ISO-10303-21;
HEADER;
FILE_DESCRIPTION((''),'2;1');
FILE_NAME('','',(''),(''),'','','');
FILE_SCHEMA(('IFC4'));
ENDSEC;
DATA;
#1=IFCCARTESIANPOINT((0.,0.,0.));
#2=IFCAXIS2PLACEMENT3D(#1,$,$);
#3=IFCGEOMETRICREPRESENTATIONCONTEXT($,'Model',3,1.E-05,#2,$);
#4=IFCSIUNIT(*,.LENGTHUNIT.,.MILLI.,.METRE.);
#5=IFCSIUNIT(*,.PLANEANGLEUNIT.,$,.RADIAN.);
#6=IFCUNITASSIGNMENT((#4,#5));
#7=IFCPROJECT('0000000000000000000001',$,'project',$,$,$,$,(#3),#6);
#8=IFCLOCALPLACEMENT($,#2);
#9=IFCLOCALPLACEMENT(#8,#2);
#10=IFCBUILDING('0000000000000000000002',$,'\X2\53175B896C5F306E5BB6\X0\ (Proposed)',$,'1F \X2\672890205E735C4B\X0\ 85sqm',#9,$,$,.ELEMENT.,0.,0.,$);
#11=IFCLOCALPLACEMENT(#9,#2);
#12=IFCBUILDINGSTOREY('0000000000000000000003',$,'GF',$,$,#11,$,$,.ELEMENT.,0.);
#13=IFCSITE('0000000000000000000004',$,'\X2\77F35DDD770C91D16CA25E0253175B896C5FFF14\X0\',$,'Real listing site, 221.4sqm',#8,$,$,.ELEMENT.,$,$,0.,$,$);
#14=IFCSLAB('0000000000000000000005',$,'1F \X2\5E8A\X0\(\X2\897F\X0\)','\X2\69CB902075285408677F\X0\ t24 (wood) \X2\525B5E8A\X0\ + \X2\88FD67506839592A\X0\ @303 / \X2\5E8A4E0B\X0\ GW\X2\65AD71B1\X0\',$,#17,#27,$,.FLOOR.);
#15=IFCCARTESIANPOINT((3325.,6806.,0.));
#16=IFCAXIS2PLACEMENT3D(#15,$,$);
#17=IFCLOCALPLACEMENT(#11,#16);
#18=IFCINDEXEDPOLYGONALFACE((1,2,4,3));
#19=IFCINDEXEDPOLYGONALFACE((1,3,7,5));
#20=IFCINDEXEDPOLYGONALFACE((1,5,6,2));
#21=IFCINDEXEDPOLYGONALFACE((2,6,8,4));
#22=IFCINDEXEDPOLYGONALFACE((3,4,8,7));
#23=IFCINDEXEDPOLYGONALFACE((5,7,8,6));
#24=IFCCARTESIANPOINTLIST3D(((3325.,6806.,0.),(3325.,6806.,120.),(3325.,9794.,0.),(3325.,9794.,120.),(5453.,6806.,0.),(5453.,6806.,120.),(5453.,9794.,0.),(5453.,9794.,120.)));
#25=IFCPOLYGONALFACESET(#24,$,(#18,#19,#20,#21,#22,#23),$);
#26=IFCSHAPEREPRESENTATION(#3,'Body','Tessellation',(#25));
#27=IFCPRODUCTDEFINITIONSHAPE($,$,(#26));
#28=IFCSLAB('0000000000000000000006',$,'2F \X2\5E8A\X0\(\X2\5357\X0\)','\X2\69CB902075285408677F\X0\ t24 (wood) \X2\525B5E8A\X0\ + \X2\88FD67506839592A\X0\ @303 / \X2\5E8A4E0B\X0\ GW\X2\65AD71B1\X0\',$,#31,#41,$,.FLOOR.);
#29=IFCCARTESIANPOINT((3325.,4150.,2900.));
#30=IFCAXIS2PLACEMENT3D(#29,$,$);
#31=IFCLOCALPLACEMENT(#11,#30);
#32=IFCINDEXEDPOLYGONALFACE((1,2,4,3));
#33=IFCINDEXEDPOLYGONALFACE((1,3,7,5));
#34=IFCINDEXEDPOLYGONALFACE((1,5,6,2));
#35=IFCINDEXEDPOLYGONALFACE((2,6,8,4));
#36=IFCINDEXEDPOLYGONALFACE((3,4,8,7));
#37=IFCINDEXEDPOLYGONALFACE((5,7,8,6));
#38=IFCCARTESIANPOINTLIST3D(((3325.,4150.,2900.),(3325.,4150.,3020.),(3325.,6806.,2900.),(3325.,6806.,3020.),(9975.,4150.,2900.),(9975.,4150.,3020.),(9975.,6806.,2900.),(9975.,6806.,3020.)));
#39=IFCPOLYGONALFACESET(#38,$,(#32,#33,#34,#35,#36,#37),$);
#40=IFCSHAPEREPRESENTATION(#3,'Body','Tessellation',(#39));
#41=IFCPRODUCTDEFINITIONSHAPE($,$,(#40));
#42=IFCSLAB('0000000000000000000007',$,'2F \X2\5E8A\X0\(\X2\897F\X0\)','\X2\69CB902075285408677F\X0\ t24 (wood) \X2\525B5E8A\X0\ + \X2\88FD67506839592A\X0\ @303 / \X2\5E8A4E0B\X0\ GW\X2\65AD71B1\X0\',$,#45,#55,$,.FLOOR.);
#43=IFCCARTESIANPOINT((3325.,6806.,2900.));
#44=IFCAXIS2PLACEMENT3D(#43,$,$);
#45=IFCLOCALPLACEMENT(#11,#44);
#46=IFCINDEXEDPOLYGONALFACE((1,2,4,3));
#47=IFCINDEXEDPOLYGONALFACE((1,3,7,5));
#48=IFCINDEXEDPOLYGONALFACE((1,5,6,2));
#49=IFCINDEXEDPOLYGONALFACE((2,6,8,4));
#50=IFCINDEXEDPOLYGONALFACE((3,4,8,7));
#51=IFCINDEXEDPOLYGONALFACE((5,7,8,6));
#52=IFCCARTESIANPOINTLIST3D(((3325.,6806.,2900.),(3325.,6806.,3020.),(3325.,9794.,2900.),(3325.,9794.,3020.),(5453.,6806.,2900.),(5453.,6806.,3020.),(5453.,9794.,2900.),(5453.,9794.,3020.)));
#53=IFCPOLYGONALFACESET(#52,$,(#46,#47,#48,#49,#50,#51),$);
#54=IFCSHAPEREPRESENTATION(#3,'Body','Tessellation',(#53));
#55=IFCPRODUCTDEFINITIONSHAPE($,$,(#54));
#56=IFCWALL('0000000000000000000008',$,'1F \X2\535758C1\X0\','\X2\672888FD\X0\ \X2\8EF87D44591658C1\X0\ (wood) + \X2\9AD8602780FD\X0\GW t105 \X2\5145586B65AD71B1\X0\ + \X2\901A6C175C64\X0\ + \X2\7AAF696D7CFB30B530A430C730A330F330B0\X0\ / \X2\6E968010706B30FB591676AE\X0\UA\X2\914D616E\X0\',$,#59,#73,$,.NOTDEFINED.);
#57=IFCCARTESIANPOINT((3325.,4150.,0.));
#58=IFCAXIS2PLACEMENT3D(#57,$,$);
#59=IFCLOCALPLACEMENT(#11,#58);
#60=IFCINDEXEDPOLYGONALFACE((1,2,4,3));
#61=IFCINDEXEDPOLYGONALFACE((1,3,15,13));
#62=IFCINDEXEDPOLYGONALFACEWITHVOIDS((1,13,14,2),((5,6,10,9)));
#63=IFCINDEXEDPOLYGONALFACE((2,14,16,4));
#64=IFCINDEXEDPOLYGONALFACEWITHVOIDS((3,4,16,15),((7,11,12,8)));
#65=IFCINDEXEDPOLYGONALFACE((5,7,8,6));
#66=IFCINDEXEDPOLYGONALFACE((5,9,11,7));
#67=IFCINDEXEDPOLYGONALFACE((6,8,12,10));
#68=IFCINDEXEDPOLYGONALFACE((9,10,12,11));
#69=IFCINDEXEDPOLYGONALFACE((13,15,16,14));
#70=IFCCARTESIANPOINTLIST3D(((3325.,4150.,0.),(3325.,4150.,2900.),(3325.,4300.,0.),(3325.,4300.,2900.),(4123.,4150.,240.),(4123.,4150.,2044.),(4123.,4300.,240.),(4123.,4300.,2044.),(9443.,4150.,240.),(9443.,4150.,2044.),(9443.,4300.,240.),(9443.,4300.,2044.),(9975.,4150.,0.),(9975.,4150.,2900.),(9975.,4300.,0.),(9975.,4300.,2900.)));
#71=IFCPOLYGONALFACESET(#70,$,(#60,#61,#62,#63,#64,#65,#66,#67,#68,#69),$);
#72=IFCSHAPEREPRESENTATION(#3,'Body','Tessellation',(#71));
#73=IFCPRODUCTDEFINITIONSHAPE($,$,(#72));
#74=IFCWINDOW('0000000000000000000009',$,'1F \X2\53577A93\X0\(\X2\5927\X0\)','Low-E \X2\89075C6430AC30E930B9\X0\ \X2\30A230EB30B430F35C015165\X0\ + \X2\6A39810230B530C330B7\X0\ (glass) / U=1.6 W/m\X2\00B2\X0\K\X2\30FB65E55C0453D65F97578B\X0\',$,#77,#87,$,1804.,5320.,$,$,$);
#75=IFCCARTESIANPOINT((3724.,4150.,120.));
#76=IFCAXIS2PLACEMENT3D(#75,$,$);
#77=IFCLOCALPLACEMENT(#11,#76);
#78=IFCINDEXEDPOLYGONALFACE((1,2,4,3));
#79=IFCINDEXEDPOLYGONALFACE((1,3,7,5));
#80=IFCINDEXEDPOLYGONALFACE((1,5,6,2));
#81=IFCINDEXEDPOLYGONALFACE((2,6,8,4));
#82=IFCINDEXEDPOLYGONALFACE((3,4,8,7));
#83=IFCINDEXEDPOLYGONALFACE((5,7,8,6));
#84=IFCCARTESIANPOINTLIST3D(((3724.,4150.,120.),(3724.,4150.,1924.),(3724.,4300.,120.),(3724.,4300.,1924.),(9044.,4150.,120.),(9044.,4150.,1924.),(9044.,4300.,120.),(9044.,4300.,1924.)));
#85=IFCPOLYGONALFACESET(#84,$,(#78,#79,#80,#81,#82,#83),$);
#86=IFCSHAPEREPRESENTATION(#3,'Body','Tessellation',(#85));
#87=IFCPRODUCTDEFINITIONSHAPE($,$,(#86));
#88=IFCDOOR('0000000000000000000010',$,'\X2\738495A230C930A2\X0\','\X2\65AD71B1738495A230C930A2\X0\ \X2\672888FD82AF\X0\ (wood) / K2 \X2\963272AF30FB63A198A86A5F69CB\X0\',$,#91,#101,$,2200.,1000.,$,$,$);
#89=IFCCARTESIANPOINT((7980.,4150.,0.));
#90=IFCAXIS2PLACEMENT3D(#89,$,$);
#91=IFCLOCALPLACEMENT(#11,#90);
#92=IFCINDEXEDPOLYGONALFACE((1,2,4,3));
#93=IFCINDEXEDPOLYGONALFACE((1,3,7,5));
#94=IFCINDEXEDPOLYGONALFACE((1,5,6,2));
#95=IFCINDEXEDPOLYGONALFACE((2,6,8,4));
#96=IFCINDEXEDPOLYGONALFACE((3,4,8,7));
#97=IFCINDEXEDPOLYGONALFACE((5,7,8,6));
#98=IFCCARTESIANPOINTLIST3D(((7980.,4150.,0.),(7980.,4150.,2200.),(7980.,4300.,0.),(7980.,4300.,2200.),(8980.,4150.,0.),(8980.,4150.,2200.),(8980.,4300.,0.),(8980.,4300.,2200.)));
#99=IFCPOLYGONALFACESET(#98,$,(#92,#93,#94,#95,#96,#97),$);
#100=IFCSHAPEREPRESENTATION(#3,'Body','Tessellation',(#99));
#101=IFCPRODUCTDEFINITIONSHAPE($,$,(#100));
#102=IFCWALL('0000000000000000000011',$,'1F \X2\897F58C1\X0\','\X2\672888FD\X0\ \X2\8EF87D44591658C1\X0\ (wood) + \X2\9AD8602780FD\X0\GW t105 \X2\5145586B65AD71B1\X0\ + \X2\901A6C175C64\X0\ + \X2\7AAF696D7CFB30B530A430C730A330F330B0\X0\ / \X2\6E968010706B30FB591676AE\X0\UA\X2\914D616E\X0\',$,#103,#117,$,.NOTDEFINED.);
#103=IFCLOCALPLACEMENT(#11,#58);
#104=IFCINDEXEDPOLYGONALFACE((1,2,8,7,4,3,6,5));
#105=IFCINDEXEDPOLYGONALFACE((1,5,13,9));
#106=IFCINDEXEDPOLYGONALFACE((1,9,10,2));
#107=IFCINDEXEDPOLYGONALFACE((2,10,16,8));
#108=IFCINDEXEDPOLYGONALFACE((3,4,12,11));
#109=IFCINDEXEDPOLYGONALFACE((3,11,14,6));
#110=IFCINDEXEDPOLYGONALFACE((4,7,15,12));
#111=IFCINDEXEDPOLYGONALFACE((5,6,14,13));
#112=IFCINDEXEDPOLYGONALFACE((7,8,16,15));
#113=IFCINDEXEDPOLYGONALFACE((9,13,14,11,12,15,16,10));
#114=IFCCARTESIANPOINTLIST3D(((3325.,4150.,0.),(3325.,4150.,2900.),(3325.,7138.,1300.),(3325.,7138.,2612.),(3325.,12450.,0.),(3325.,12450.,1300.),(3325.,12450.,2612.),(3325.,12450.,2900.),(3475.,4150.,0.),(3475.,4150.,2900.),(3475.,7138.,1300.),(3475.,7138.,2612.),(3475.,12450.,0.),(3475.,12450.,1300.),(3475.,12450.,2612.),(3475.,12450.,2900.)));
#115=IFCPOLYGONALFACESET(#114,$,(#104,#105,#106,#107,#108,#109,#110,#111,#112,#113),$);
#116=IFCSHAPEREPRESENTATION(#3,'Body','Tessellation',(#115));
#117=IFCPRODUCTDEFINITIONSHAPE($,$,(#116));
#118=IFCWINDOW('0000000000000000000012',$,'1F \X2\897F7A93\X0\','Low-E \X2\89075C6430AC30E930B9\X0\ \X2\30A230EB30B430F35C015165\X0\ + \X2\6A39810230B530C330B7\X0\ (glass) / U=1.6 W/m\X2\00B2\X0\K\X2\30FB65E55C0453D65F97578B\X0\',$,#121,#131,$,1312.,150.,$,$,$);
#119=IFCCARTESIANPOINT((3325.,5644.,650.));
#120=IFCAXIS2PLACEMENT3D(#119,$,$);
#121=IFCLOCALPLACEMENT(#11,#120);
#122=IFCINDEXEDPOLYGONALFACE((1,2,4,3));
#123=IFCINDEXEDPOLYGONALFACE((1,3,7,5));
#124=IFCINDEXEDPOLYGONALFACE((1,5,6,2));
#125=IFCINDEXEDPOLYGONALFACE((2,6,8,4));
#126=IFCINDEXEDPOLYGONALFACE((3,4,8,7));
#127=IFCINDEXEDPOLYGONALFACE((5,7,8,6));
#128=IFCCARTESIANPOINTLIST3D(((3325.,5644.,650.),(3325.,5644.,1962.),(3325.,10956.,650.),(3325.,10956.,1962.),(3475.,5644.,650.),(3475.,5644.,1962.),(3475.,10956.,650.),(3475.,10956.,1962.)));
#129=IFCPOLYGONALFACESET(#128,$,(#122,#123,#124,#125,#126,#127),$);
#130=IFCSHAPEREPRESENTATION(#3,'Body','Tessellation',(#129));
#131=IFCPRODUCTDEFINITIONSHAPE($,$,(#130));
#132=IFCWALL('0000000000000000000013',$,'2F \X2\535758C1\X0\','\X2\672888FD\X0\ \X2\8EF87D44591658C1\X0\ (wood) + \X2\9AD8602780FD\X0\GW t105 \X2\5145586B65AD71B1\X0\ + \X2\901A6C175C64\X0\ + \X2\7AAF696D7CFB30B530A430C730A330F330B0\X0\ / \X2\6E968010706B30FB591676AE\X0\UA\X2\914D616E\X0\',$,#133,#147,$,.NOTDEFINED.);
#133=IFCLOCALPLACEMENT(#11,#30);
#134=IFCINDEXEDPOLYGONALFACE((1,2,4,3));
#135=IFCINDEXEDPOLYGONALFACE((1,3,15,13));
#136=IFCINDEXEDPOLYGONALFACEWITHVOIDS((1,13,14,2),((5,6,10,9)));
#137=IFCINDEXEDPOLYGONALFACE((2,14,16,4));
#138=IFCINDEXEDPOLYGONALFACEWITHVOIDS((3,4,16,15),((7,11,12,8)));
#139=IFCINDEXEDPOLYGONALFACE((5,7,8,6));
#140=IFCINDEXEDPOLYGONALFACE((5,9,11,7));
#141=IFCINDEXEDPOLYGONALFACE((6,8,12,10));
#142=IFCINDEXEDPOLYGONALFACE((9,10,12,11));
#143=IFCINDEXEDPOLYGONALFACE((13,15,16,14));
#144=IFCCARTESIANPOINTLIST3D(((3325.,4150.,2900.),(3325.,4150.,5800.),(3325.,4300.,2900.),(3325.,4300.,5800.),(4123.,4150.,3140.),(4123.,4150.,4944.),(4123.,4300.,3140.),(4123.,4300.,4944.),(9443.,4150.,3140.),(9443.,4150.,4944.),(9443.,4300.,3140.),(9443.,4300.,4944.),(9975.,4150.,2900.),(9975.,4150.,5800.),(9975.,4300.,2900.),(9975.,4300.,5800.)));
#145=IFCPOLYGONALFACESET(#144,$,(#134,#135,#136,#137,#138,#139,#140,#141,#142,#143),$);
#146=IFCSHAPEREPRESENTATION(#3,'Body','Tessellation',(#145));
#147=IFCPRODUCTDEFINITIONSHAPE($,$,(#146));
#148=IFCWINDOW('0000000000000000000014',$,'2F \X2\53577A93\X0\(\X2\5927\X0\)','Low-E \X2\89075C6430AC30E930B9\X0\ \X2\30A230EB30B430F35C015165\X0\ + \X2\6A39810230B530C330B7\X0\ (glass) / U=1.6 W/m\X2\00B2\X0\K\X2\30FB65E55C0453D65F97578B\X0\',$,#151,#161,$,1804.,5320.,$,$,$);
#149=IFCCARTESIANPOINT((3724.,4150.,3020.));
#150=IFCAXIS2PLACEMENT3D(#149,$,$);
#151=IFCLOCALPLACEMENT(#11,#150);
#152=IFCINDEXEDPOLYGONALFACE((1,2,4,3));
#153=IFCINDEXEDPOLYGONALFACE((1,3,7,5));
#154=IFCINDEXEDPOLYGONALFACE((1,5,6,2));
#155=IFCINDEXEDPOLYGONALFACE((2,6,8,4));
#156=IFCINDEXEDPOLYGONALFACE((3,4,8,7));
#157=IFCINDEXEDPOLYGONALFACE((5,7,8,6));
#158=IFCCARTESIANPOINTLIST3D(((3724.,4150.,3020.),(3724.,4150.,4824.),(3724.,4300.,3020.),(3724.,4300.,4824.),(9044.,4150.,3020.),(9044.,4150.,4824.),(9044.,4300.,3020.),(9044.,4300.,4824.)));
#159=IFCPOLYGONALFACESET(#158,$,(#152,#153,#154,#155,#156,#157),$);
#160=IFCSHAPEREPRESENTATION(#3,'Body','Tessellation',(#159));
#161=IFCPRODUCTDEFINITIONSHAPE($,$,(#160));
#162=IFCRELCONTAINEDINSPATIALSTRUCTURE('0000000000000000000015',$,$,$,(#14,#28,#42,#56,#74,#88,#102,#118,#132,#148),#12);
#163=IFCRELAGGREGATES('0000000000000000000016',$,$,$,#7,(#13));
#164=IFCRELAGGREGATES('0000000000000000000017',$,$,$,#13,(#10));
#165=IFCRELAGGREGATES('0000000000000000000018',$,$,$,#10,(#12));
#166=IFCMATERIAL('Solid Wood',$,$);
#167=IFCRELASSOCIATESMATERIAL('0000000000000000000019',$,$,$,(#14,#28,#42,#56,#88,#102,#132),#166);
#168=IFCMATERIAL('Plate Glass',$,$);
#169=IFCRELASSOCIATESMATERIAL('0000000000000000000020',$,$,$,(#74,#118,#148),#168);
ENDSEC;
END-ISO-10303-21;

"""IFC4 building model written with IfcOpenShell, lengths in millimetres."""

from ifc_helpers import new_model, si_unit, frame, frame_2d, origin, place, context, project, spatial, rectangle, extrude, material, element, fill, save


model = new_model("IFC4")

# Units and contexts
model_context = context("Model", 3, precision=1e-05, world=origin())
ifc_project = project(units=[si_unit("LENGTHUNIT", "METRE", prefix="MILLI"), si_unit("PLANEANGLEUNIT", "RADIAN")], contexts=[model_context])

# Site, building, storey
site_placement = place(None, origin())
site = spatial("IfcSite", under=ifc_project, at=site_placement, Name="石川県金沢市北安江４", ObjectType="Real listing site, 221.4sqm", CompositionType="ELEMENT", RefElevation=0.0)
building_placement = place(site_placement, origin())
building = spatial("IfcBuilding", under=site, at=building_placement, Name="北安江の家 (Proposed)", ObjectType="1F 木造平屋 85sqm", CompositionType="ELEMENT", ElevationOfRefHeight=0.0, ElevationOfTerrain=0.0)
storey_placement = place(building_placement, origin())
storey = spatial("IfcBuildingStorey", under=building, at=storey_placement, Name="GF", CompositionType="ELEMENT", Elevation=0.0)

# Slabs
ifc_material_1 = material(Name="Solid Wood")
slab_1_placement = place(storey_placement, frame((3325.0, 6806.0, 0.0)))
element("IfcSlab", 1, at=slab_1_placement, inside=storey, material=ifc_material_1, Name="1F 床(西)", Description="構造用合板 t24 (wood) 剛床 + 製材根太 @303 / 床下 GW断熱", PredefinedType="FLOOR", context=model_context, shape_type="SweptSolid", body=[
    extrude(rectangle(XDim=2128.0, YDim=2988.0, at=frame_2d((1064.0, 1494.0))), frame((3325.0, 6806.0, 0.0)), (0.0, 0.0, 1.0), 120.0),
])
slab_2_placement = place(storey_placement, frame((3325.0, 4150.0, 2900.0)))
element("IfcSlab", 2, at=slab_2_placement, inside=storey, material=ifc_material_1, Name="2F 床(南)", Description="構造用合板 t24 (wood) 剛床 + 製材根太 @303 / 床下 GW断熱", PredefinedType="FLOOR", context=model_context, shape_type="SweptSolid", body=[
    extrude(rectangle(XDim=6650.0, YDim=2656.0, at=frame_2d((3325.0, 1328.0))), frame((3325.0, 4150.0, 2900.0)), (0.0, 0.0, 1.0), 120.0),
])
slab_3_placement = place(storey_placement, frame((3325.0, 6806.0, 2900.0)))
element("IfcSlab", 3, at=slab_3_placement, inside=storey, material=ifc_material_1, Name="2F 床(西)", Description="構造用合板 t24 (wood) 剛床 + 製材根太 @303 / 床下 GW断熱", PredefinedType="FLOOR", context=model_context, shape_type="SweptSolid", body=[
    extrude(rectangle(XDim=2128.0, YDim=2988.0, at=frame_2d((1064.0, 1494.0))), frame((3325.0, 6806.0, 2900.0)), (0.0, 0.0, 1.0), 120.0),
])

# Wall, openings, window, door
wall_1_placement = place(storey_placement, frame((3325.0, 4150.0, 0.0)))
wall_1 = element("IfcWall", 4, at=wall_1_placement, inside=storey, material=ifc_material_1, Name="1F 南壁", Description="木製 軸組外壁 (wood) + 高性能GW t105 充填断熱 + 通気層 + 窯業系サイディング / 準耐火・外皮UA配慮", PredefinedType="NOTDEFINED", context=model_context, shape_type="SweptSolid", body=[
    extrude(rectangle(XDim=6650.0, YDim=150.0, at=frame_2d((3325.0, 75.0))), frame((3325.0, 4150.0, 0.0)), (0.0, 0.0, 1.0), 2900.0),
])
opening_1_placement = place(storey_placement, frame((3724.0, 4150.0, 120.0)))
opening_1 = element("IfcOpeningElement", 5, at=opening_1_placement, cuts=wall_1, PredefinedType="NOTDEFINED", context=model_context, shape_type="SweptSolid", body=[
    extrude(rectangle(XDim=5320.0, YDim=150.0, at=frame_2d((2660.0, 75.0))), frame((3724.0, 4150.0, 120.0)), (0.0, 0.0, 1.0), 1804.0),
])
opening_2_placement = place(storey_placement, frame((7980.0, 4150.0, 0.0)))
opening_2 = element("IfcOpeningElement", 6, at=opening_2_placement, cuts=wall_1, PredefinedType="NOTDEFINED", context=model_context, shape_type="SweptSolid", body=[
    extrude(rectangle(XDim=1000.0, YDim=150.0, at=frame_2d((500.0, 75.0))), frame((7980.0, 4150.0, 0.0)), (0.0, 0.0, 1.0), 2200.0),
])
ifc_material_2 = material(Name="Plate Glass")
window_1_placement = place(storey_placement, frame((3724.0, 4150.0, 120.0)))
window_1 = element("IfcWindow", 7, at=window_1_placement, inside=storey, material=ifc_material_2, Name="1F 南窓(大)", Description="Low-E 複層ガラス アルゴン封入 + 樹脂サッシ (glass) / U=1.6 W/m²K・日射取得型", OverallHeight=1804.0, OverallWidth=5320.0, context=model_context, shape_type="SweptSolid", body=[
    extrude(rectangle(XDim=5320.0, YDim=150.0, at=frame_2d((2660.0, 75.0))), frame((3724.0, 4150.0, 120.0)), (0.0, 0.0, 1.0), 1804.0),
])
fill(opening_1, window_1)
door_placement = place(storey_placement, frame((7980.0, 4150.0, 0.0)))
door = element("IfcDoor", 8, at=door_placement, inside=storey, material=ifc_material_1, Name="玄関ドア", Description="断熱玄関ドア 木製芯 (wood) / K2 防犯・採風機構", OverallHeight=2200.0, OverallWidth=1000.0, context=model_context, shape_type="SweptSolid", body=[
    extrude(rectangle(XDim=1000.0, YDim=150.0, at=frame_2d((500.0, 75.0))), frame((7980.0, 4150.0, 0.0)), (0.0, 0.0, 1.0), 2200.0),
])
fill(opening_2, door)

# Walls, openings, windows
wall_2_placement = place(storey_placement, frame((3325.0, 4150.0, 0.0)))
wall_2 = element("IfcWall", 9, at=wall_2_placement, inside=storey, material=ifc_material_1, Name="1F 西壁", Description="木製 軸組外壁 (wood) + 高性能GW t105 充填断熱 + 通気層 + 窯業系サイディング / 準耐火・外皮UA配慮", PredefinedType="NOTDEFINED", context=model_context, shape_type="SweptSolid", body=[
    extrude(rectangle(XDim=150.0, YDim=8300.0, at=frame_2d((75.0, 4150.0))), frame((3325.0, 4150.0, 0.0)), (0.0, 0.0, 1.0), 2900.0),
])
opening_3_placement = place(storey_placement, frame((3325.0, 5644.0, 650.0)))
opening_3 = element("IfcOpeningElement", 10, at=opening_3_placement, cuts=wall_2, PredefinedType="NOTDEFINED", context=model_context, shape_type="SweptSolid", body=[
    extrude(rectangle(XDim=150.0, YDim=5312.0, at=frame_2d((75.0, 2656.0))), frame((3325.0, 5644.0, 650.0)), (0.0, 0.0, 1.0), 1312.0),
])
window_2_placement = place(storey_placement, frame((3325.0, 5644.0, 650.0)))
window_2 = element("IfcWindow", 11, at=window_2_placement, inside=storey, material=ifc_material_2, Name="1F 西窓", Description="Low-E 複層ガラス アルゴン封入 + 樹脂サッシ (glass) / U=1.6 W/m²K・日射取得型", OverallHeight=1312.0, OverallWidth=150.0, context=model_context, shape_type="SweptSolid", body=[
    extrude(rectangle(XDim=150.0, YDim=5312.0, at=frame_2d((75.0, 2656.0))), frame((3325.0, 5644.0, 650.0)), (0.0, 0.0, 1.0), 1312.0),
])
fill(opening_3, window_2)
wall_3_placement = place(storey_placement, frame((3325.0, 4150.0, 2900.0)))
wall_3 = element("IfcWall", 12, at=wall_3_placement, inside=storey, material=ifc_material_1, Name="2F 南壁", Description="木製 軸組外壁 (wood) + 高性能GW t105 充填断熱 + 通気層 + 窯業系サイディング / 準耐火・外皮UA配慮", PredefinedType="NOTDEFINED", context=model_context, shape_type="SweptSolid", body=[
    extrude(rectangle(XDim=6650.0, YDim=150.0, at=frame_2d((3325.0, 75.0))), frame((3325.0, 4150.0, 2900.0)), (0.0, 0.0, 1.0), 2900.0),
])
opening_4_placement = place(storey_placement, frame((3724.0, 4150.0, 3020.0)))
opening_4 = element("IfcOpeningElement", 13, at=opening_4_placement, cuts=wall_3, PredefinedType="NOTDEFINED", context=model_context, shape_type="SweptSolid", body=[
    extrude(rectangle(XDim=5320.0, YDim=150.0, at=frame_2d((2660.0, 75.0))), frame((3724.0, 4150.0, 3020.0)), (0.0, 0.0, 1.0), 1804.0),
])
window_3_placement = place(storey_placement, frame((3724.0, 4150.0, 3020.0)))
window_3 = element("IfcWindow", 14, at=window_3_placement, inside=storey, material=ifc_material_2, Name="2F 南窓(大)", Description="Low-E 複層ガラス アルゴン封入 + 樹脂サッシ (glass) / U=1.6 W/m²K・日射取得型", OverallHeight=1804.0, OverallWidth=5320.0, context=model_context, shape_type="SweptSolid", body=[
    extrude(rectangle(XDim=5320.0, YDim=150.0, at=frame_2d((2660.0, 75.0))), frame((3724.0, 4150.0, 3020.0)), (0.0, 0.0, 1.0), 1804.0),
])
fill(opening_4, window_3)

save(model, "model.ifc")
